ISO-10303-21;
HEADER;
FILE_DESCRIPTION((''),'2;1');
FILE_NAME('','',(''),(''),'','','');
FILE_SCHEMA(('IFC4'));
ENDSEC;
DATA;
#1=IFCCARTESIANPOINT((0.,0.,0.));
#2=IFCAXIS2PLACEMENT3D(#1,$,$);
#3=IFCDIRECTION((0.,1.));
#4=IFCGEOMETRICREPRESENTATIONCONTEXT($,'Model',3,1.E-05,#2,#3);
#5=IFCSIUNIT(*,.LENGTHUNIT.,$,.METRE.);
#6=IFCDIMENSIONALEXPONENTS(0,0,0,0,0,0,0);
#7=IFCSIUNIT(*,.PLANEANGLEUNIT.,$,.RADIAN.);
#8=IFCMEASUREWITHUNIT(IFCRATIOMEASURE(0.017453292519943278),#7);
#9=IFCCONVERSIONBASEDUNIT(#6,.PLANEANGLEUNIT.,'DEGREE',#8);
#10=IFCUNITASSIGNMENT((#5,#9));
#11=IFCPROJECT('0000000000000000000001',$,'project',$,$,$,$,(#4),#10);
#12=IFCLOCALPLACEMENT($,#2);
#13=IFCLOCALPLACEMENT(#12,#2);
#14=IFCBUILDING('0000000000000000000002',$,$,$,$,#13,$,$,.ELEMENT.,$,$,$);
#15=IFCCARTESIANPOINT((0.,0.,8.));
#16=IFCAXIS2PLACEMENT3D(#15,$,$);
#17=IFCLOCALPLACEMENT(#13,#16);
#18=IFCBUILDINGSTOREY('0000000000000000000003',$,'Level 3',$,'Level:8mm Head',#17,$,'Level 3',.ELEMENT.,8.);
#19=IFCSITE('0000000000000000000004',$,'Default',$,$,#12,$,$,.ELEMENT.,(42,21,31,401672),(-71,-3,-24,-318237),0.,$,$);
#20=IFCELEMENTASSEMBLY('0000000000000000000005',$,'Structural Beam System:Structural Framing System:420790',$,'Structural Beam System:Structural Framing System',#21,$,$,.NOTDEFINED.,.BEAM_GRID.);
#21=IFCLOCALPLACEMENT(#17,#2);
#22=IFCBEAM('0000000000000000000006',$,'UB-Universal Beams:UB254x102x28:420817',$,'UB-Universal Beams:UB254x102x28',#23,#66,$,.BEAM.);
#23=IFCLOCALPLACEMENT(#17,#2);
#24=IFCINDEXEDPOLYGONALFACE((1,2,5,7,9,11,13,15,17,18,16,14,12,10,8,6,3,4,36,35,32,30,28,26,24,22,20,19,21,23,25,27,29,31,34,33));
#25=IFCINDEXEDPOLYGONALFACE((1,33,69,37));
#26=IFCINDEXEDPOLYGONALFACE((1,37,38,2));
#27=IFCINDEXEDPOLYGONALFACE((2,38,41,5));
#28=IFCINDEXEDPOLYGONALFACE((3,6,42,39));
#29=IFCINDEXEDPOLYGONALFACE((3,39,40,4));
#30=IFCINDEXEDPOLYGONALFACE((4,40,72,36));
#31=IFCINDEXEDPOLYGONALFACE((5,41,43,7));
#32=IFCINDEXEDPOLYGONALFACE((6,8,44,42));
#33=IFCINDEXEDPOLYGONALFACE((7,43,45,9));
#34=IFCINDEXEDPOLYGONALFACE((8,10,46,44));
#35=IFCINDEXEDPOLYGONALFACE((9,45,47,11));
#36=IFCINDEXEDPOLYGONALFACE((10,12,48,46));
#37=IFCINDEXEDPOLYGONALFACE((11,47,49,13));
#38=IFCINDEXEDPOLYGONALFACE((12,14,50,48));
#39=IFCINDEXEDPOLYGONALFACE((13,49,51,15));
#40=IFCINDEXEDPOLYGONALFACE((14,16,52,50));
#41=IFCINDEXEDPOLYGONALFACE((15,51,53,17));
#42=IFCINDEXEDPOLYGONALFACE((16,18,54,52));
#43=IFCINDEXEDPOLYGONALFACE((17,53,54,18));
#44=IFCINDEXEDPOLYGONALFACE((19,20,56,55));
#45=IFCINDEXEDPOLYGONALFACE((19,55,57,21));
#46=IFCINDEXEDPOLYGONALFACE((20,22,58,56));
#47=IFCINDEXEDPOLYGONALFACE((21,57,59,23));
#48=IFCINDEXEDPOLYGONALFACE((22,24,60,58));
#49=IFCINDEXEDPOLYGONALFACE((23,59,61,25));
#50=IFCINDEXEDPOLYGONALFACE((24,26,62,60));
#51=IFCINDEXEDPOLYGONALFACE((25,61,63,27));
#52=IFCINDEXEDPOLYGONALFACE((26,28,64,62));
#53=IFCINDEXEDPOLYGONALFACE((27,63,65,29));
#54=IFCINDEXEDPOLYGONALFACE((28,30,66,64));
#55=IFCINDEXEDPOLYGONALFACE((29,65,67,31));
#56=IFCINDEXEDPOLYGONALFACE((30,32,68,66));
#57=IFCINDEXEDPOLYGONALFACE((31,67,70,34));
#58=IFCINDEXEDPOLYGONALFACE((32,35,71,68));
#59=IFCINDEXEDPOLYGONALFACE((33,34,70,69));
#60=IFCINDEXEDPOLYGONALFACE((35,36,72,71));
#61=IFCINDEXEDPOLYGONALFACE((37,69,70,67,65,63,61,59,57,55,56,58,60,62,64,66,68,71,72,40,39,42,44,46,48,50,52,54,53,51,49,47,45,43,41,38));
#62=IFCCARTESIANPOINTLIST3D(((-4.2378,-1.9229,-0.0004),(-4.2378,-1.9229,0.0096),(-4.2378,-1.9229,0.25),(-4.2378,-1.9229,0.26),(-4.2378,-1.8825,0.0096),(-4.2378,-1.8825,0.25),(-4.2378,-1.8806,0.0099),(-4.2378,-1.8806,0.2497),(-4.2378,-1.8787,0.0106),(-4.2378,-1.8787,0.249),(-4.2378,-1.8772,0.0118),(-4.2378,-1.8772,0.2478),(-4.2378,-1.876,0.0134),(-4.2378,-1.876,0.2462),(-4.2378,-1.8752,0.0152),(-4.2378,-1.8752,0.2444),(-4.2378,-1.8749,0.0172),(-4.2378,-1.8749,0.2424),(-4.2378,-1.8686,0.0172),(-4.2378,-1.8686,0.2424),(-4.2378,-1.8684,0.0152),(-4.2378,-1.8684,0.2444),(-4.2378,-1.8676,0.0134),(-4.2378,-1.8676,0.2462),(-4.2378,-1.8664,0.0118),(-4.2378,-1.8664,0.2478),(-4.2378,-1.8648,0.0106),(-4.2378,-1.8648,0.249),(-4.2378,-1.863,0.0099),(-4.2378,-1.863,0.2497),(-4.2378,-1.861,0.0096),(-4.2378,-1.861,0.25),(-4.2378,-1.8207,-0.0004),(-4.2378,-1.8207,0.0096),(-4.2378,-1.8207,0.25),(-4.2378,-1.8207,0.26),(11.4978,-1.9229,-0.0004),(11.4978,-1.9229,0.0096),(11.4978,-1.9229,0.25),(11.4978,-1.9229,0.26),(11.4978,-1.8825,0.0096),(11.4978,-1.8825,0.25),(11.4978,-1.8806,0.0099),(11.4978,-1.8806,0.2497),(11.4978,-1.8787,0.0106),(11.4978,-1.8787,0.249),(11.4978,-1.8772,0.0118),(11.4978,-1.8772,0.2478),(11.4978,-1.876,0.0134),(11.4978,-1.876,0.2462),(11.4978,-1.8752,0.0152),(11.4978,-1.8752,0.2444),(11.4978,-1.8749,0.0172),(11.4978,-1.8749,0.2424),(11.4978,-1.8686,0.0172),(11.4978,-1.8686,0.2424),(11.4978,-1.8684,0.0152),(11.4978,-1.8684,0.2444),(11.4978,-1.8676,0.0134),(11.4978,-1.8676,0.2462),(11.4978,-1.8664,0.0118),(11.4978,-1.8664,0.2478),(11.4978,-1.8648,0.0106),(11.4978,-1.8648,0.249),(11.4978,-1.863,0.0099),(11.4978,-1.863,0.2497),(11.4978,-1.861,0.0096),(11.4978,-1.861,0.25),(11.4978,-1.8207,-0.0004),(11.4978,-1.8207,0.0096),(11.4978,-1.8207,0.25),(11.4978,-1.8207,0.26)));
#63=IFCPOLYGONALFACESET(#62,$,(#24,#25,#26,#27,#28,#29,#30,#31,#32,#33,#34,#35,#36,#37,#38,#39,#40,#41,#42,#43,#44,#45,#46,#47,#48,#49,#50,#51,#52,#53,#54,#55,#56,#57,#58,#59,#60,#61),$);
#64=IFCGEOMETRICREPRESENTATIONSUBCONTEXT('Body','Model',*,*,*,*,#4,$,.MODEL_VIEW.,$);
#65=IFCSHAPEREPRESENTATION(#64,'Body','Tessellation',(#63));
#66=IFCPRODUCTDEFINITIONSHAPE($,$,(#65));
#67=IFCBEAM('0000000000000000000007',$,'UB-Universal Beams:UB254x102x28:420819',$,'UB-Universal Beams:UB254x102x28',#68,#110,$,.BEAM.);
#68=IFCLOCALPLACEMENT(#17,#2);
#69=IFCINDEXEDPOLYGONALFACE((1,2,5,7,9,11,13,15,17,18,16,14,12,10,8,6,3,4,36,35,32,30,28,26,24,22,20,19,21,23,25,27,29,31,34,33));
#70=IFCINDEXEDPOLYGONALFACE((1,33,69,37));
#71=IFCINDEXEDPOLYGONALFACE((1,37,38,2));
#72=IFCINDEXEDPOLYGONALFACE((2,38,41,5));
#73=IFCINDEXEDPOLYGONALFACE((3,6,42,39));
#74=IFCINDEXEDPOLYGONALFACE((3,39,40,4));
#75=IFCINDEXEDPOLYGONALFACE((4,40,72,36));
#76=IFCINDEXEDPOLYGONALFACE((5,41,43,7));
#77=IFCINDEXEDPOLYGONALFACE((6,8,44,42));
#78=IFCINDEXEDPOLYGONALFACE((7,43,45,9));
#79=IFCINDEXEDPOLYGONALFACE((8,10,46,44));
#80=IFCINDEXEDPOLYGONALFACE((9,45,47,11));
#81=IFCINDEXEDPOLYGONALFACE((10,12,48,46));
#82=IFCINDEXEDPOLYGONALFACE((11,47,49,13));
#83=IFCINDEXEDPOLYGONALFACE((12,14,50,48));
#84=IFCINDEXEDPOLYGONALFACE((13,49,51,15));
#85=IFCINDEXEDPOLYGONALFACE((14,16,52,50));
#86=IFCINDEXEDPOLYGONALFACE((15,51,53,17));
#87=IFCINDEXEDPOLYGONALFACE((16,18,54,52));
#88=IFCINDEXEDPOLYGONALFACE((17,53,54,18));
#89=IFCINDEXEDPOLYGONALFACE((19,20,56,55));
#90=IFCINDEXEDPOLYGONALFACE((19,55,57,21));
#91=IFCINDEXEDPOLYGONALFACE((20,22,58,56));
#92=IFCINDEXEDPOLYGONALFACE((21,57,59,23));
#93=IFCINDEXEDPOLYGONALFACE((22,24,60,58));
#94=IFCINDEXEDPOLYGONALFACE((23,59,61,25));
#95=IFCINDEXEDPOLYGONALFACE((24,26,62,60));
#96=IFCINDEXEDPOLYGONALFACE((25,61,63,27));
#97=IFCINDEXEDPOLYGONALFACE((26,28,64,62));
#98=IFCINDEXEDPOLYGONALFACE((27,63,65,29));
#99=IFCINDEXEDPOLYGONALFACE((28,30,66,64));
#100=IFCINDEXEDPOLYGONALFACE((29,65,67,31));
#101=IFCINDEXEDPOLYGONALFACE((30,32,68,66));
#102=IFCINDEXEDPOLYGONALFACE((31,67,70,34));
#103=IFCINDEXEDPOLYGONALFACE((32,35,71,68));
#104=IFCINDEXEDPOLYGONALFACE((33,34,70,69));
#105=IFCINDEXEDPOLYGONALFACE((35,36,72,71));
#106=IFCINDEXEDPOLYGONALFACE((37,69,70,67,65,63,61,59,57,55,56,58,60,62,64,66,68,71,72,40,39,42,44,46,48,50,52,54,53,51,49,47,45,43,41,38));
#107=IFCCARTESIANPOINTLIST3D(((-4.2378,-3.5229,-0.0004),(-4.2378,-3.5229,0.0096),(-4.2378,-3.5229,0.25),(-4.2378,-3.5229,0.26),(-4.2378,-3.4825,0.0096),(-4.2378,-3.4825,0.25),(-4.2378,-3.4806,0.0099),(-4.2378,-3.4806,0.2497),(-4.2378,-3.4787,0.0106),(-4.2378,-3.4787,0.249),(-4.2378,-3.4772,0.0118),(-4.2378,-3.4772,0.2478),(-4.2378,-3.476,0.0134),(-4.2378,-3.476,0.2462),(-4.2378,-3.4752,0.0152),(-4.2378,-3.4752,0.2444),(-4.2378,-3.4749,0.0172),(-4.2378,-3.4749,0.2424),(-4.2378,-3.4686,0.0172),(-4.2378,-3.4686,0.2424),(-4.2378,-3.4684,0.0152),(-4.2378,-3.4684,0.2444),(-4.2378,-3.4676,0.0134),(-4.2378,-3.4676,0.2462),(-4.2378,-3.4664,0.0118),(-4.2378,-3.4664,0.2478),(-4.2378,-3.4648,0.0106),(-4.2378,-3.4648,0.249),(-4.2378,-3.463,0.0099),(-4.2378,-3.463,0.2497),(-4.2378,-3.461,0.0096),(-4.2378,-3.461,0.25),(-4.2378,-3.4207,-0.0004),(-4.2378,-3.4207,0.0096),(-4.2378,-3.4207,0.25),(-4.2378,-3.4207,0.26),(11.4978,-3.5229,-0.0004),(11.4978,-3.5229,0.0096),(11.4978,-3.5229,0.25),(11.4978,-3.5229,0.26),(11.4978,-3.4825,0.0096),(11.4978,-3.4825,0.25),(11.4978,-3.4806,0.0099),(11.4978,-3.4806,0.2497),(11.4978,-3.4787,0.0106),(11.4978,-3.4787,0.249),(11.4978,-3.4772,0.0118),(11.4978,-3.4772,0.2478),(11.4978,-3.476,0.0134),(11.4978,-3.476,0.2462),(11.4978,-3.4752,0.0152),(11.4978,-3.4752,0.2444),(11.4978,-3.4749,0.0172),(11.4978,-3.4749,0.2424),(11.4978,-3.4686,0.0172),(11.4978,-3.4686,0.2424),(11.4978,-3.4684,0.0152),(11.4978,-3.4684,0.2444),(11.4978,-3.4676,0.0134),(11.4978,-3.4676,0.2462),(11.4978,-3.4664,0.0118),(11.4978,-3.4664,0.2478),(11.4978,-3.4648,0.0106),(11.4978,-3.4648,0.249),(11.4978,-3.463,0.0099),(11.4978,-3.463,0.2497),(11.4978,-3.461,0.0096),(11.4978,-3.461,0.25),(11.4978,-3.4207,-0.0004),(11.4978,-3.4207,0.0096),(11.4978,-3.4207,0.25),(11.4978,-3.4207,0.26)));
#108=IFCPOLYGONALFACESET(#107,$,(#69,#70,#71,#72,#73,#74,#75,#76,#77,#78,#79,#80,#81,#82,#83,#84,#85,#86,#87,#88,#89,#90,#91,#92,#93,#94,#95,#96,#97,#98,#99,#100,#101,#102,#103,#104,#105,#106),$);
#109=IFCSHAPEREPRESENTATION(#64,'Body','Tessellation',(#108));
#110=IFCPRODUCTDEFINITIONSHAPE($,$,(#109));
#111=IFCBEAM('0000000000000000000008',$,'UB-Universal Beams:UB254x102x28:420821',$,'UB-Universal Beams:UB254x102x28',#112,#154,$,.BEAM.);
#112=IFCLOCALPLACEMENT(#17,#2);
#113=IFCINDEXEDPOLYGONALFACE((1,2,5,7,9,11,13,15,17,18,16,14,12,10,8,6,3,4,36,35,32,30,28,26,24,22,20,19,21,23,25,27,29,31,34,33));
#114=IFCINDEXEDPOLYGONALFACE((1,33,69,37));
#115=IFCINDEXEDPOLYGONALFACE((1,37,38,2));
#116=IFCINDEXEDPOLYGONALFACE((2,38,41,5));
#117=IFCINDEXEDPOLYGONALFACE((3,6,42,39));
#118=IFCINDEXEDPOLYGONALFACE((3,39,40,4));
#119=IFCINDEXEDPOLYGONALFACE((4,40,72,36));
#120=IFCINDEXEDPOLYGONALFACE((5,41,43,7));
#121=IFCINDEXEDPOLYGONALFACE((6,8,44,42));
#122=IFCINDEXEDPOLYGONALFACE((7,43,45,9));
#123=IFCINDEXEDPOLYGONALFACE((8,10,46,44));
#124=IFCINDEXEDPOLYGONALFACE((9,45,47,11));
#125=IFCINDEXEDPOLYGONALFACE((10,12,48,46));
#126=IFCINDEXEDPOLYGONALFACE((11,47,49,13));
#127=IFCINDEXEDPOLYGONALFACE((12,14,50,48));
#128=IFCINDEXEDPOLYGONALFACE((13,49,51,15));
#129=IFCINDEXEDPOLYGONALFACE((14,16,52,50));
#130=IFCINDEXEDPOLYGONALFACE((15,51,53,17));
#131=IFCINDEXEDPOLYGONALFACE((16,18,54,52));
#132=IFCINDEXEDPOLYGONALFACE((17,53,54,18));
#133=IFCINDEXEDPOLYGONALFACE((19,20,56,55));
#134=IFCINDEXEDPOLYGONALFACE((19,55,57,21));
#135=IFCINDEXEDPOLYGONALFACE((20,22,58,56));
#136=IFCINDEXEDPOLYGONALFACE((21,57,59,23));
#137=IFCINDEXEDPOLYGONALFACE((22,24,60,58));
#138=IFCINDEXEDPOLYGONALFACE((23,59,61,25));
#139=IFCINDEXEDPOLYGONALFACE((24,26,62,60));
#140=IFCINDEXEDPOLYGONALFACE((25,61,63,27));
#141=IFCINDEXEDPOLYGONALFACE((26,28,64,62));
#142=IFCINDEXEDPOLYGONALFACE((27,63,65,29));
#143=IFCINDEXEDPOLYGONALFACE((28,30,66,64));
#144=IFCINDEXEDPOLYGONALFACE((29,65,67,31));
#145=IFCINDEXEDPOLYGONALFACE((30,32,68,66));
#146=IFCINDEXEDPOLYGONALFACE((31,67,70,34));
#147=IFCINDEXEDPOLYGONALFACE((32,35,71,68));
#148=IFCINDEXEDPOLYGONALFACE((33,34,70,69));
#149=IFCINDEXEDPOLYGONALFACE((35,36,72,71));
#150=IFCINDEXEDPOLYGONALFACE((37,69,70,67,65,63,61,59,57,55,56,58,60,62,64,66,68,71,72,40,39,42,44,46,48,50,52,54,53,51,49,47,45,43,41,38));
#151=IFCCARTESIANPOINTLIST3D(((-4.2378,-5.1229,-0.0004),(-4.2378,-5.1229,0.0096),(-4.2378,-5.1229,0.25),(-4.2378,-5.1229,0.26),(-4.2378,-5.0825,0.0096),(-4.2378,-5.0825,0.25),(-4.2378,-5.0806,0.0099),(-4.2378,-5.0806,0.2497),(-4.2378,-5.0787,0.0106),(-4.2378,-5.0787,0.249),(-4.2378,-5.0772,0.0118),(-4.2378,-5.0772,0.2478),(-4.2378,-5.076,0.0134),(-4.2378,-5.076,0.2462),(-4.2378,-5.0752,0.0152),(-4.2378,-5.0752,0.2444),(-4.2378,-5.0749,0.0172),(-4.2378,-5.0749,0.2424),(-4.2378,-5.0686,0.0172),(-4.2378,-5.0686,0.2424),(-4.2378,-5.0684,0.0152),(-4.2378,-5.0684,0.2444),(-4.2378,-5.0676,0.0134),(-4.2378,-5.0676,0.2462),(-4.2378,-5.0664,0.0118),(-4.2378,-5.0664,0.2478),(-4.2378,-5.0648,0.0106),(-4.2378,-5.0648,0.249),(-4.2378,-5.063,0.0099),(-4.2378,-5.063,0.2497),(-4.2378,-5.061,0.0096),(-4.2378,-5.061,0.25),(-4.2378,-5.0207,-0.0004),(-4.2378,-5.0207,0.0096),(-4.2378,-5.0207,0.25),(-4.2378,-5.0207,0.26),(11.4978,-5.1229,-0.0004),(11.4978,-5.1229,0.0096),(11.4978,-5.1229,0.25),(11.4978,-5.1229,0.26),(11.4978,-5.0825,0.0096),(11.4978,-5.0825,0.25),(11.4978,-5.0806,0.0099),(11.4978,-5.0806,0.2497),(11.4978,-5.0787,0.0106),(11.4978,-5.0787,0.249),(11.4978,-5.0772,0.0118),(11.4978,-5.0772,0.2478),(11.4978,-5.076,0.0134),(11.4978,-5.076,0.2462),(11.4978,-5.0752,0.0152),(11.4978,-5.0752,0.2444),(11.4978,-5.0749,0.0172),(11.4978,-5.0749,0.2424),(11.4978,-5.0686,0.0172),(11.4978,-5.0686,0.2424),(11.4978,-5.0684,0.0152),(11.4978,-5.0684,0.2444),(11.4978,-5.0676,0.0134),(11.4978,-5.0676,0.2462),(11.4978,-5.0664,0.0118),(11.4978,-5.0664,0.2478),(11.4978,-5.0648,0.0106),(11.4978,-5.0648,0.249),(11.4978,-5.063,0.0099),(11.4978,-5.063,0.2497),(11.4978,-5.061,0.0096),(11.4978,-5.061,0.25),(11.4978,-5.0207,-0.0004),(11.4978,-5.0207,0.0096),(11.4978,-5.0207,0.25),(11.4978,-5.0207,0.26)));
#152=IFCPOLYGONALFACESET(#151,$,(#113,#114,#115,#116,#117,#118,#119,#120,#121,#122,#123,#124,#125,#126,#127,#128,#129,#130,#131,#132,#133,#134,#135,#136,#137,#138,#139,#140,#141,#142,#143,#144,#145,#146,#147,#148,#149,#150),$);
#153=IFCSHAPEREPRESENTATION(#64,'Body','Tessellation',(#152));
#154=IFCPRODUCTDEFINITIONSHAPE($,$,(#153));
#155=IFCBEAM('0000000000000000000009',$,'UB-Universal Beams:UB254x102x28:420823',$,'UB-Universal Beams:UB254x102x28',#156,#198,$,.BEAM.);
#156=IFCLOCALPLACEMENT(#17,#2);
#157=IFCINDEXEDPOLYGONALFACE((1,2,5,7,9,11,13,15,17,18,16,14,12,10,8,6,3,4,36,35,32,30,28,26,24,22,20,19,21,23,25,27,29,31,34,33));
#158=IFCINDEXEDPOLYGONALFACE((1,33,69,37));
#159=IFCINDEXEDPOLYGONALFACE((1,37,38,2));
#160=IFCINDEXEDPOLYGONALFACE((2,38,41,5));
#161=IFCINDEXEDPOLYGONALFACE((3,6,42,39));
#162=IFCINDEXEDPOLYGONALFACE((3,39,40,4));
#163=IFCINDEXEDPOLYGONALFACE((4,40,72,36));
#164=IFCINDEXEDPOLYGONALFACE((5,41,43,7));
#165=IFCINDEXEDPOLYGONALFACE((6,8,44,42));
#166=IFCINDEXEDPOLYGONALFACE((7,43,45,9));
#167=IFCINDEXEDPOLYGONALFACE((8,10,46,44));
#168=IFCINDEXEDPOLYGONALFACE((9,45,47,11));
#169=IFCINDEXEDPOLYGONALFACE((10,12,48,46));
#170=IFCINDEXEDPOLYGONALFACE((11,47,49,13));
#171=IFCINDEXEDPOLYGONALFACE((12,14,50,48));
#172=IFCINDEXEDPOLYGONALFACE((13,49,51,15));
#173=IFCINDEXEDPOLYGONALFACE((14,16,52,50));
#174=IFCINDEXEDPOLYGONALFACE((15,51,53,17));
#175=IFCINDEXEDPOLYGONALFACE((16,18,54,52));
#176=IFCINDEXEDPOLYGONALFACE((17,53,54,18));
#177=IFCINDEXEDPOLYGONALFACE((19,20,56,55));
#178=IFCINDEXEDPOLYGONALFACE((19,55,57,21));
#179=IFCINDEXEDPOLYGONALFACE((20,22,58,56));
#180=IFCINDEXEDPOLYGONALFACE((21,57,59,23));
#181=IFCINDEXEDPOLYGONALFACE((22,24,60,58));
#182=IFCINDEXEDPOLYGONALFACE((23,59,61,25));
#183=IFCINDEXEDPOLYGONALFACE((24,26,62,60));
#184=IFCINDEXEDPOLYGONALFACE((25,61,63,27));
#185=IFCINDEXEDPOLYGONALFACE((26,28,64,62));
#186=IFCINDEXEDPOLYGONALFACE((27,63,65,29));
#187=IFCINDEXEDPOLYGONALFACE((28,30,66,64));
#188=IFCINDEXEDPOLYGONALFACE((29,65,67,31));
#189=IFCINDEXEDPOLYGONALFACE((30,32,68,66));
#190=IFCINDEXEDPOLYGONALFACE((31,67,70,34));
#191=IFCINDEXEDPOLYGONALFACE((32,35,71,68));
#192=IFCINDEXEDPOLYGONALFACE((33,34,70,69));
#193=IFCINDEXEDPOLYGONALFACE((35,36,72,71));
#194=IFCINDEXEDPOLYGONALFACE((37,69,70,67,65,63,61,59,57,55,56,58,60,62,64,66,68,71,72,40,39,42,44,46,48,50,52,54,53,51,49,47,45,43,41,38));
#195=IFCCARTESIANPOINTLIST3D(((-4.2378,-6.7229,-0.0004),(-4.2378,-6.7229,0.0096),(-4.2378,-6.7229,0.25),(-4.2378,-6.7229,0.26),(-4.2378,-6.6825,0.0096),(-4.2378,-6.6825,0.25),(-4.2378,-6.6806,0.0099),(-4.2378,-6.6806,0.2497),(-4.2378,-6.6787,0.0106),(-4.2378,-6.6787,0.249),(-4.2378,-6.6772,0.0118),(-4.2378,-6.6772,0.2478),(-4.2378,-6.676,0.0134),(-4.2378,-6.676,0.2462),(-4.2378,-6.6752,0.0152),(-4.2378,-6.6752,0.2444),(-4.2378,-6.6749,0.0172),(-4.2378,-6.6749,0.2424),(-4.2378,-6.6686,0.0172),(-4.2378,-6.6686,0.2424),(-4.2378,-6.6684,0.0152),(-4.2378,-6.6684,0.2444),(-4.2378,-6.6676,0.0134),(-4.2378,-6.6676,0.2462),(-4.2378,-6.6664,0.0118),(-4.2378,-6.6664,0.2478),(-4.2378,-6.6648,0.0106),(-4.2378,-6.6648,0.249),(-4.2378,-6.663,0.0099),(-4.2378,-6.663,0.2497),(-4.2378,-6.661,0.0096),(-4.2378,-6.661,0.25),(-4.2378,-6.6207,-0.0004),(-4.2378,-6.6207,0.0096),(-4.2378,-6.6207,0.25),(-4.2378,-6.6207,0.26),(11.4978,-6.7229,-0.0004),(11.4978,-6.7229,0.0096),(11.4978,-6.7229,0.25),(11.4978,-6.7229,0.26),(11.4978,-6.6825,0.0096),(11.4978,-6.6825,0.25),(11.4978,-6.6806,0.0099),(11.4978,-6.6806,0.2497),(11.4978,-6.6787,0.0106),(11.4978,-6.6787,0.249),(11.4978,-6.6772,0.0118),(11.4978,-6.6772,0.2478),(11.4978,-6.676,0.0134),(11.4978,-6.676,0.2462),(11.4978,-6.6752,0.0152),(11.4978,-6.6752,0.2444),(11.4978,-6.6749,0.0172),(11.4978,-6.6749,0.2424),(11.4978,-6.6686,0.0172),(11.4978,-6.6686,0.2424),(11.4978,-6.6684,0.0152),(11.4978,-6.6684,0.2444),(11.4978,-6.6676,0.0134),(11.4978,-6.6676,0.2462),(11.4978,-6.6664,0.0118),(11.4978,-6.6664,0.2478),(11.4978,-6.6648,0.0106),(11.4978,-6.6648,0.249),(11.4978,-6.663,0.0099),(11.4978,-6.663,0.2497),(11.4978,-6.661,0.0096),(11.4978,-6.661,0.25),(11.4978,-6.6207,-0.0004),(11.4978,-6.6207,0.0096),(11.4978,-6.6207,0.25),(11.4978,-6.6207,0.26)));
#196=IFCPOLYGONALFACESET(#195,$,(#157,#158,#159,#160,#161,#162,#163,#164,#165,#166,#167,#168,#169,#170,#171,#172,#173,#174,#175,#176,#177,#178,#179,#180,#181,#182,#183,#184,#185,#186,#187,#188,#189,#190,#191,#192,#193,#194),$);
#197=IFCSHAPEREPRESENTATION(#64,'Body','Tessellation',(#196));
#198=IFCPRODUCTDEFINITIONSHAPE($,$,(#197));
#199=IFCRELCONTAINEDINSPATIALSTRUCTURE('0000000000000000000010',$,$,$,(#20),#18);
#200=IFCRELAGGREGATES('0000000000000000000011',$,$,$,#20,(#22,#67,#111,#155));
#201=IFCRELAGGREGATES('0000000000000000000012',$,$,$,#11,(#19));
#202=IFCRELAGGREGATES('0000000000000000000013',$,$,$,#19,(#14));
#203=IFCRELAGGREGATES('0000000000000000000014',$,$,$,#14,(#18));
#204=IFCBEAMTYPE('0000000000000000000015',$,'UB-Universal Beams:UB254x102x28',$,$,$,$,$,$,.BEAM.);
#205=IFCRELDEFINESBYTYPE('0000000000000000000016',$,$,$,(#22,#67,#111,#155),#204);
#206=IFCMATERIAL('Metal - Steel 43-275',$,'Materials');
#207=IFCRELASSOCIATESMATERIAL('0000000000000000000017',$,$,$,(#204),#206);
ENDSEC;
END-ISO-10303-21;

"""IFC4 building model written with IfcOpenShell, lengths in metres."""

from ifc_helpers import new_model, entity, si_unit, converted_unit, direction, frame, frame_2d, origin, place, context, subcontext, project, spatial, i_section, extrude, source, transform, mapped, material, material_profile, profile_set, type_object, type_shapes, element, aggregate, save


model = new_model("IFC4")

# Units and contexts
model_context = context("Model", 3, precision=1e-05, world=origin(), true_north=direction((0.0, 1.0)))
body_context = subcontext(model_context, "Body", "Model", "MODEL_VIEW")
ifc_project = project(units=[si_unit("LENGTHUNIT", "METRE"), converted_unit("PLANEANGLEUNIT", "DEGREE", entity("IfcRatioMeasure", 0.017453292519943278), si_unit("PLANEANGLEUNIT", "RADIAN"), dimensions=[0, 0, 0, 0, 0, 0, 0])], contexts=[model_context])

# Site, building, storey
site_placement = place(None, origin())
site = spatial("IfcSite", under=ifc_project, at=site_placement, Name="Default", CompositionType="ELEMENT", RefLatitude=(42, 21, 31, 401672), RefLongitude=(-71, -3, -24, -318237), RefElevation=0.0)
building_placement = place(site_placement, origin())
building = spatial("IfcBuilding", under=site, at=building_placement, CompositionType="ELEMENT")
storey_placement = place(building_placement, frame((0.0, 0.0, 8.0)))
storey = spatial("IfcBuildingStorey", under=building, at=storey_placement, Name="Level 3", ObjectType="Level:8mm Head", LongName="Level 3", CompositionType="ELEMENT", Elevation=8.0)

# Shared definitions
ifc_material_1 = material(Name="Metal - Steel 43-275", Category="Materials")

# Element assembly, beams
assembly_placement = place(storey_placement, origin())
assembly = element("IfcElementAssembly", 1, at=assembly_placement, inside=storey, Name="Structural Beam System:Structural Framing System:420790", ObjectType="Structural Beam System:Structural Framing System", AssemblyPlace="NOTDEFINED", PredefinedType="BEAM_GRID")
ifc_material_profile_1 = material_profile(ifc_material_1, i_section(OverallWidth=0.1022, OverallDepth=0.2604, WebThickness=0.0063, FlangeThickness=0.01, FilletRadius=0.0076, at=frame_2d((0.0, 0.0), x_axis=(0.0, 1.0))), Name="UB254x102x28")
ifc_profile_set_1 = profile_set([ifc_material_profile_1], Name="UB254x102x28")
beam_type_1 = type_object("IfcBeamType", Name="UB-Universal Beams:UB254x102x28", PredefinedType="BEAM", material=ifc_profile_set_1)
shared_shape_1 = source(origin(), body_context, "Body", "SweptSolid", [
    extrude(i_section(OverallWidth=0.1022, OverallDepth=0.2604, WebThickness=0.0063, FlangeThickness=0.01, FilletRadius=0.0076, at=frame_2d((0.0, 0.0), x_axis=(0.0, 1.0))), frame((-7.8373, 0.0, 0.0), z_axis=(1.0, 0.0, 0.0), x_axis=(0.0, 0.0, -1.0)), (0.0, 0.0, 1.0), 15.7356),
])
type_shapes(beam_type_1, [shared_shape_1])
beam_1_placement = place(assembly_placement, frame((3.5995, -1.8718, 0.1298)))
beam_1 = element("IfcBeam", 2, at=beam_1_placement, type_object=beam_type_1, Name="UB-Universal Beams:UB254x102x28:420817", ObjectType="UB-Universal Beams:UB254x102x28", PredefinedType="BEAM", context=body_context, shape_type="MappedRepresentation", body=[
    mapped(shared_shape_1, transform((0.0, 0.0, 0.0), scale=1.0)),
])
beam_2_placement = place(assembly_placement, frame((3.5995, -3.4718, 0.1298)))
beam_2 = element("IfcBeam", 3, at=beam_2_placement, type_object=beam_type_1, Name="UB-Universal Beams:UB254x102x28:420819", ObjectType="UB-Universal Beams:UB254x102x28", PredefinedType="BEAM", context=body_context, shape_type="MappedRepresentation", body=[
    mapped(shared_shape_1, transform((0.0, 0.0, 0.0), scale=1.0)),
])
beam_3_placement = place(assembly_placement, frame((3.5995, -5.0718, 0.1298)))
beam_3 = element("IfcBeam", 4, at=beam_3_placement, type_object=beam_type_1, Name="UB-Universal Beams:UB254x102x28:420821", ObjectType="UB-Universal Beams:UB254x102x28", PredefinedType="BEAM", context=body_context, shape_type="MappedRepresentation", body=[
    mapped(shared_shape_1, transform((0.0, 0.0, 0.0), scale=1.0)),
])
beam_4_placement = place(assembly_placement, frame((3.5995, -6.6718, 0.1298)))
beam_4 = element("IfcBeam", 5, at=beam_4_placement, type_object=beam_type_1, Name="UB-Universal Beams:UB254x102x28:420823", ObjectType="UB-Universal Beams:UB254x102x28", PredefinedType="BEAM", context=body_context, shape_type="MappedRepresentation", body=[
    mapped(shared_shape_1, transform((0.0, 0.0, 0.0), scale=1.0)),
])
aggregate(assembly, [beam_1, beam_2, beam_3, beam_4])

save(model, "model.ifc")
